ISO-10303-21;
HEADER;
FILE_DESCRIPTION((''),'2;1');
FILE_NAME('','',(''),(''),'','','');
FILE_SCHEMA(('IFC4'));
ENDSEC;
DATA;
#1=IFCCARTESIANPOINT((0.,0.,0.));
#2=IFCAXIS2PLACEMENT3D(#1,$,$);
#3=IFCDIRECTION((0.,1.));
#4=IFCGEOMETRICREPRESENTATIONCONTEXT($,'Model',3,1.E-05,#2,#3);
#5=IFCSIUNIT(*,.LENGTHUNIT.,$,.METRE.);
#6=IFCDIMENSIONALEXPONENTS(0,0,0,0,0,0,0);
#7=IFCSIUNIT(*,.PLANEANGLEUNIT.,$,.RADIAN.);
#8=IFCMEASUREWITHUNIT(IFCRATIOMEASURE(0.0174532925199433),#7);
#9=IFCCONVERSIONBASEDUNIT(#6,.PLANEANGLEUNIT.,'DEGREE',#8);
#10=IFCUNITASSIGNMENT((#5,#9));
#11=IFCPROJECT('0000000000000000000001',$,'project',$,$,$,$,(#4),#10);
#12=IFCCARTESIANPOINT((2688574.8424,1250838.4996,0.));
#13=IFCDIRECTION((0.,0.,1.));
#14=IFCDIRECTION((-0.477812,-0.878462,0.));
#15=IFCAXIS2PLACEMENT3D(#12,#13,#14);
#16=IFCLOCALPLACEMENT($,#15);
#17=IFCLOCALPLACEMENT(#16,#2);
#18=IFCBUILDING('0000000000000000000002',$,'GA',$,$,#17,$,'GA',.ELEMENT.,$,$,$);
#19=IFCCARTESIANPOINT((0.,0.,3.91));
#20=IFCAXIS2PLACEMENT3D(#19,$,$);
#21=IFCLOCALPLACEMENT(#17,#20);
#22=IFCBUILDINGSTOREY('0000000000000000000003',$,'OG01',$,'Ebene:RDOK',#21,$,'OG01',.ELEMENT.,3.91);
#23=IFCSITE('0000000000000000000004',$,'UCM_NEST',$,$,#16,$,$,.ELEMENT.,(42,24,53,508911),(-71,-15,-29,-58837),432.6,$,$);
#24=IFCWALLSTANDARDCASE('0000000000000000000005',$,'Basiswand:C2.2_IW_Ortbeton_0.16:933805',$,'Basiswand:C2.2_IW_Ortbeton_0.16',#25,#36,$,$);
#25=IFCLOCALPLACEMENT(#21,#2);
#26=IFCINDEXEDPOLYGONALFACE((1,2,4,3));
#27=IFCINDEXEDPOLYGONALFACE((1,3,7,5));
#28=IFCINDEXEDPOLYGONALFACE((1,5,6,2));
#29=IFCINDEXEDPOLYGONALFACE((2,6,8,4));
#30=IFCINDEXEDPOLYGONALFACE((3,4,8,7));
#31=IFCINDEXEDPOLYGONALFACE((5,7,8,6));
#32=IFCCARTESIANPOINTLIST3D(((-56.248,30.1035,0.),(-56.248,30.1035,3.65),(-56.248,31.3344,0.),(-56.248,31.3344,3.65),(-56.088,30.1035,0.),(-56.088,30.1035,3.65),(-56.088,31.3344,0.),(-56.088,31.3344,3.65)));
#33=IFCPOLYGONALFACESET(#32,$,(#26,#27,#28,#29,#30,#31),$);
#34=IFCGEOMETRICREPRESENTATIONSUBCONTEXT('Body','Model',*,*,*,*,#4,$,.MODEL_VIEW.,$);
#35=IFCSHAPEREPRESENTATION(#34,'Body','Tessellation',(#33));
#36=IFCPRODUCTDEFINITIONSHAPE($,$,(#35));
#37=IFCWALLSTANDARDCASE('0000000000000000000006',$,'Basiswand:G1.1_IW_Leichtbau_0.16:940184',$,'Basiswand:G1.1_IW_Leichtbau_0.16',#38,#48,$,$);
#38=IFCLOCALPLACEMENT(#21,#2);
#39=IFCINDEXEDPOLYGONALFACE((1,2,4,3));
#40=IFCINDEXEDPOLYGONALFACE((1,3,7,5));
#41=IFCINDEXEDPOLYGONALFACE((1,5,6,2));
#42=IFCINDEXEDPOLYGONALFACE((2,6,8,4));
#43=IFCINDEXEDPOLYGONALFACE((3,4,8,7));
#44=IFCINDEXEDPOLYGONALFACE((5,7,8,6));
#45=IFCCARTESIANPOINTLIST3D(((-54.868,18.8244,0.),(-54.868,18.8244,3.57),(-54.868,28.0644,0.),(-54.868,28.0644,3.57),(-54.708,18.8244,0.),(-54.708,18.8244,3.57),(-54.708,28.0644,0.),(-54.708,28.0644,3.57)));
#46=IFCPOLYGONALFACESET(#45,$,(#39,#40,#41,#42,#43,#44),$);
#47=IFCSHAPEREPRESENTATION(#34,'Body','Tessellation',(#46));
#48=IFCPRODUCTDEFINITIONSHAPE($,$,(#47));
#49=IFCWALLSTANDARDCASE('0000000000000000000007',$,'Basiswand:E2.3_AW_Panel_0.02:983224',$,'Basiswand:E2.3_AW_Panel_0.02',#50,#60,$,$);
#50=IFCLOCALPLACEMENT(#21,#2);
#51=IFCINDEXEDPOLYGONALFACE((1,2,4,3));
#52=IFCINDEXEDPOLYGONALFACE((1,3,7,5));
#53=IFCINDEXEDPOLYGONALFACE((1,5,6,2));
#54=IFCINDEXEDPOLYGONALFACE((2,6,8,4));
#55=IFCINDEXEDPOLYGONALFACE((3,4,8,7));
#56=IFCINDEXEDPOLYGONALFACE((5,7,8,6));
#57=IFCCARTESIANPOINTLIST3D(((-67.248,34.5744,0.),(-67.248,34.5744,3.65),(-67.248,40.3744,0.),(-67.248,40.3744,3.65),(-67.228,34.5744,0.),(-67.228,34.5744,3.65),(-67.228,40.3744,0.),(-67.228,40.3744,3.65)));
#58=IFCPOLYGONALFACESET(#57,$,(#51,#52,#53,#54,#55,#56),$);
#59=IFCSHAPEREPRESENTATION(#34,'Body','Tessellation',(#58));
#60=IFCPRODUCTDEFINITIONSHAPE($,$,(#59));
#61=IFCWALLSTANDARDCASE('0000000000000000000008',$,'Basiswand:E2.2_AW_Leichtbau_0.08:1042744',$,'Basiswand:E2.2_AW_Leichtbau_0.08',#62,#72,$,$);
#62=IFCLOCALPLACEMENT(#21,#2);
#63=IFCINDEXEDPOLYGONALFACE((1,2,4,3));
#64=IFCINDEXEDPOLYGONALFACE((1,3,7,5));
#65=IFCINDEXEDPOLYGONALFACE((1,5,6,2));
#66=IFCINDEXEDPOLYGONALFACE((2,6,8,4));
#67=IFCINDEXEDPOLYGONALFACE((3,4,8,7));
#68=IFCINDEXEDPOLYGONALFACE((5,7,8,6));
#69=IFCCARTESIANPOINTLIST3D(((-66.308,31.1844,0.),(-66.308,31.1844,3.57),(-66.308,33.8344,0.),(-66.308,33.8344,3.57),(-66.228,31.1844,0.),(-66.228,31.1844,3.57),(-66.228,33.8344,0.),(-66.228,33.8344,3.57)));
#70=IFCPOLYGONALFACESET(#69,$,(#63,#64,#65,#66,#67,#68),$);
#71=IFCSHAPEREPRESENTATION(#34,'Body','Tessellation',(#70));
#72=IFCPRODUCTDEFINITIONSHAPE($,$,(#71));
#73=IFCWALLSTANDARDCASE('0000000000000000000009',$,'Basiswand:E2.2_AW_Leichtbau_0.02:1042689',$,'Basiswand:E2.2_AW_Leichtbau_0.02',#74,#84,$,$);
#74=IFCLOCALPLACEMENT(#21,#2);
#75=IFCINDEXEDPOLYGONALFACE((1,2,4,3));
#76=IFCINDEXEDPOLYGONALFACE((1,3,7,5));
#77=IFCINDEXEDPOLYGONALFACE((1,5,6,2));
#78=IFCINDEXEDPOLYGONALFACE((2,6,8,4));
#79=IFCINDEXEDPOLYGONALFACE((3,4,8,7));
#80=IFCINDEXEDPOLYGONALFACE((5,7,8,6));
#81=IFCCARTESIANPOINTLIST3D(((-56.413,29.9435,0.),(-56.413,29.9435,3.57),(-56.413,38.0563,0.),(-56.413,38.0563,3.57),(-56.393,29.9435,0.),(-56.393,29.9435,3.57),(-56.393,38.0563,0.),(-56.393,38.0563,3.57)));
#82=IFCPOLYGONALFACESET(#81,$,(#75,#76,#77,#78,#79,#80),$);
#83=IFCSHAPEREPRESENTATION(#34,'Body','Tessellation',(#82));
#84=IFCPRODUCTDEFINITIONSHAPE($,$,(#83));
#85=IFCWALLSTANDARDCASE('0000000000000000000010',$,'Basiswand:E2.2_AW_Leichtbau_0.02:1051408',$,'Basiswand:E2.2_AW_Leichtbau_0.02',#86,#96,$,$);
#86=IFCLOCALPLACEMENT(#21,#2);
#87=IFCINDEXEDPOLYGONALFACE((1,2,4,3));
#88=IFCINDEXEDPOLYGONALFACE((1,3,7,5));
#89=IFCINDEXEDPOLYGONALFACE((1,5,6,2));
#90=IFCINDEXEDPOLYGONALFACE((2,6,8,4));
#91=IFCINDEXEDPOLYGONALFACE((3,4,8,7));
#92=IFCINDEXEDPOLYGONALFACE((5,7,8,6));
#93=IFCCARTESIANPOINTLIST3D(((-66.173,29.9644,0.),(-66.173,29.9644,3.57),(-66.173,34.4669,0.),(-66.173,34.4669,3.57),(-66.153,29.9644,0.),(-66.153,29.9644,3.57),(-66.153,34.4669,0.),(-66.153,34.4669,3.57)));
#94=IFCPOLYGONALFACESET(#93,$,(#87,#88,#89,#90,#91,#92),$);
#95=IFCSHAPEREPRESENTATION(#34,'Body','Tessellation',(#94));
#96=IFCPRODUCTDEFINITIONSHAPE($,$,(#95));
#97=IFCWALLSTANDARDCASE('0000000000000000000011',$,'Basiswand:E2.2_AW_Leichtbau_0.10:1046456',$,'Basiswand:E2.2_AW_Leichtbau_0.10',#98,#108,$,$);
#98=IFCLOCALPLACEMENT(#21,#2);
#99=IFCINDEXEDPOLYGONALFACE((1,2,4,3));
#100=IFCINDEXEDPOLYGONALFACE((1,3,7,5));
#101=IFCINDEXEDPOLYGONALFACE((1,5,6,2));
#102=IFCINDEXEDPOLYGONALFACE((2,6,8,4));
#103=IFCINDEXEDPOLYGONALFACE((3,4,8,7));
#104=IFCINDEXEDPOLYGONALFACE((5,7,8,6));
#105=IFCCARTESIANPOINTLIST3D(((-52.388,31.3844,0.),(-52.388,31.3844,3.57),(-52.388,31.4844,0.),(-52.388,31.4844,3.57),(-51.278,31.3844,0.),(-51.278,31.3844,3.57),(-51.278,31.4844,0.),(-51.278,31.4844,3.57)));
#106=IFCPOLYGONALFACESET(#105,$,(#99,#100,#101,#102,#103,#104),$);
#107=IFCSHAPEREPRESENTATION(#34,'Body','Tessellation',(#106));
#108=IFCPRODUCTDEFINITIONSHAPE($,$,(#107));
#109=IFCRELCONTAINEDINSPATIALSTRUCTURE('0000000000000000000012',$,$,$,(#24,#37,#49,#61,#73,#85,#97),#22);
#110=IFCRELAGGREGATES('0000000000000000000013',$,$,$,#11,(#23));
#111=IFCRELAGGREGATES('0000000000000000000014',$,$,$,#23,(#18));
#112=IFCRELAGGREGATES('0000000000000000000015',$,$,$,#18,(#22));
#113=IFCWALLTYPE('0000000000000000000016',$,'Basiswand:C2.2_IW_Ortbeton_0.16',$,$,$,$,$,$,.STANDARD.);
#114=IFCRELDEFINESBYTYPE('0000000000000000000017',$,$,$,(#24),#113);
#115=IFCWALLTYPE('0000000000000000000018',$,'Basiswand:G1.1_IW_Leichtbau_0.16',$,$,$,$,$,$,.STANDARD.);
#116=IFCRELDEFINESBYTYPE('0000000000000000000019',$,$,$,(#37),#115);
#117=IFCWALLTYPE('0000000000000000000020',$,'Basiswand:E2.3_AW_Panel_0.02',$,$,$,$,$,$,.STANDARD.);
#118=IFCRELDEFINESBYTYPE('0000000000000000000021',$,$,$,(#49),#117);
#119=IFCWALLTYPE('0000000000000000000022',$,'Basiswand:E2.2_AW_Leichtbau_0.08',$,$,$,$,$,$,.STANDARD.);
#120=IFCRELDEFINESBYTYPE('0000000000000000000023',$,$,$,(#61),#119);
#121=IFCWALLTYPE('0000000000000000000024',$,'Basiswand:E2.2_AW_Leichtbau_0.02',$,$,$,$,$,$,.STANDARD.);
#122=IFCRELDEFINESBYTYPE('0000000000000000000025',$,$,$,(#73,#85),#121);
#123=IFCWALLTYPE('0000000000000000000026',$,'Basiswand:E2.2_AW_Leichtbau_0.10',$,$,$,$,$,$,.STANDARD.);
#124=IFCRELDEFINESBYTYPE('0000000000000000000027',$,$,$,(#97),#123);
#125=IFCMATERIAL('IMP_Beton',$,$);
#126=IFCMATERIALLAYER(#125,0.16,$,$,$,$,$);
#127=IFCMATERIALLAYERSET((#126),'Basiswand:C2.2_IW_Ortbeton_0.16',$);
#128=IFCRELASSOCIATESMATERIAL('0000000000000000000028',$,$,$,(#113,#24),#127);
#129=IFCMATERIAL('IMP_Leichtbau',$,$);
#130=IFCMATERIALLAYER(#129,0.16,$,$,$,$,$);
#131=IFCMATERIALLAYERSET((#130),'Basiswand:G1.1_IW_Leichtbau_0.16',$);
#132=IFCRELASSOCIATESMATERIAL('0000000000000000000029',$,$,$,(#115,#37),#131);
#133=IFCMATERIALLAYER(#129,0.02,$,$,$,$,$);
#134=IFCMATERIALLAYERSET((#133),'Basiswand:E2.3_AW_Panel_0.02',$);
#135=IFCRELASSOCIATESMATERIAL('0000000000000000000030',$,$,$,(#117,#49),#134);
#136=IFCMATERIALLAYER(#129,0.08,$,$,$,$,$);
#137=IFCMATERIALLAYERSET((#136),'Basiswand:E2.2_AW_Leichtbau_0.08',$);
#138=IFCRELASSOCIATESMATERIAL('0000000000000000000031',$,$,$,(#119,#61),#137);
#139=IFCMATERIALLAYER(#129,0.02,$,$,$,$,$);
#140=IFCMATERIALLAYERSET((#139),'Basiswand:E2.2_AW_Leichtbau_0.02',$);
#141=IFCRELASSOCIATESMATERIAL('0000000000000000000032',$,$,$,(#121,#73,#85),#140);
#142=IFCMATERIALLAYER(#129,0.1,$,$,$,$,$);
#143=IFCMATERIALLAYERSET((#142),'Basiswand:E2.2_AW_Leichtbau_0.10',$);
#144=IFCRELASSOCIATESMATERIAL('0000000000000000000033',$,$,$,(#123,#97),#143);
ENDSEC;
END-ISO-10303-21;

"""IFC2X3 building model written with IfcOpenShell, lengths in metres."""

from ifc_helpers import new_model, entity, si_unit, converted_unit, direction, frame, frame_2d, origin, place, context, subcontext, project, spatial, polyline, rectangle, extrude, clip, bounded_halfspace, material, layer, layer_set, layer_usage, type_object, element, save


model = new_model("IFC2X3")

# Units and contexts
model_context = context("Model", 3, precision=1e-05, world=origin(), true_north=direction((0.0, 1.0)))
body_context = subcontext(model_context, "Body", "Model", "MODEL_VIEW")
ifc_project = project(units=[si_unit("LENGTHUNIT", "METRE"), converted_unit("PLANEANGLEUNIT", "DEGREE", entity("IfcRatioMeasure", 0.0174532925199433), si_unit("PLANEANGLEUNIT", "RADIAN"), dimensions=[0, 0, 0, 0, 0, 0, 0])], contexts=[model_context])

# Site, building, storey
site_placement = place(None, frame((2688574.8424, 1250838.4996, 0.0), z_axis=(0.0, 0.0, 1.0), x_axis=(-0.477812, -0.878462, 0.0)))
site = spatial("IfcSite", under=ifc_project, at=site_placement, Name="UCM_NEST", CompositionType="ELEMENT", RefLatitude=(42, 24, 53, 508911), RefLongitude=(-71, -15, -29, -58837), RefElevation=432.6)
building_placement = place(site_placement, origin())
building = spatial("IfcBuilding", under=site, at=building_placement, Name="GA", LongName="GA", CompositionType="ELEMENT")
storey_placement = place(building_placement, frame((0.0, 0.0, 3.91)))
storey = spatial("IfcBuildingStorey", under=building, at=storey_placement, Name="OG01", ObjectType="Ebene:RDOK", LongName="OG01", CompositionType="ELEMENT", Elevation=3.91)

# Shared definitions
ifc_material_1 = material(Name="IMP_Beton")

# Shared definitions
ifc_material_2 = material(Name="IMP_Leichtbau")

# Wall
ifc_layer_1 = layer(ifc_material_1, 0.16)
ifc_layer_set_1 = layer_set([ifc_layer_1], Name="Basiswand:C2.2_IW_Ortbeton_0.16")
ifc_layer_usage_1 = layer_usage(ifc_layer_set_1, "AXIS2", "NEGATIVE", 0.08)
wall_type_1 = type_object("IfcWallType", Name="Basiswand:C2.2_IW_Ortbeton_0.16", PredefinedType="STANDARD", material=ifc_layer_set_1)
wall_1_placement = place(storey_placement, frame((-56.168, 31.3344, 0.0), z_axis=(0.0, 0.0, 1.0), x_axis=(0.0, -1.0, 0.0)))
element("IfcWallStandardCase", 1, at=wall_1_placement, inside=storey, type_object=wall_type_1, material=ifc_layer_usage_1, Name="Basiswand:C2.2_IW_Ortbeton_0.16:933805", ObjectType="Basiswand:C2.2_IW_Ortbeton_0.16", context=body_context, shape_type="SweptSolid", body=[
    extrude(rectangle(XDim=1.2309, YDim=0.16, at=frame_2d((0.6155, 0.0), x_axis=(-1.0, 0.0))), origin(), (0.0, 0.0, 1.0), 3.65),
])

# Shared definitions
ifc_layer_2 = layer(ifc_material_2, 0.16)
ifc_layer_set_2 = layer_set([ifc_layer_2], Name="Basiswand:G1.1_IW_Leichtbau_0.16")
wall_type_2 = type_object("IfcWallType", Name="Basiswand:G1.1_IW_Leichtbau_0.16", PredefinedType="STANDARD", material=ifc_layer_set_2)

# Walls
ifc_layer_usage_2 = layer_usage(ifc_layer_set_2, "AXIS2", "NEGATIVE", 0.08)
wall_2_placement = place(storey_placement, frame((-54.788, 28.0644, 0.0), z_axis=(0.0, 0.0, 1.0), x_axis=(0.0, -1.0, 0.0)))
element("IfcWallStandardCase", 2, at=wall_2_placement, inside=storey, type_object=wall_type_2, material=ifc_layer_usage_2, Name="Basiswand:G1.1_IW_Leichtbau_0.16:940184", ObjectType="Basiswand:G1.1_IW_Leichtbau_0.16", context=body_context, shape_type="Clipping", body=[
    clip(extrude(rectangle(XDim=9.24, YDim=0.16, at=frame_2d((4.62, 0.0), x_axis=(-1.0, 0.0))), origin(), (0.0, 0.0, 1.0), 3.57), bounded_halfspace(frame((0.0, -0.08, 3.57), z_axis=(0.0, 0.0, -1.0), x_axis=(1.0, 0.0, 0.0)), True, frame((0.0, -0.08, 3.57), z_axis=(0.0, 0.0, -1.0), x_axis=(1.0, 0.0, 0.0)), polyline([(0.0, 0.0), (0.0, -0.16), (9.24, -0.16), (9.24, 0.0), (0.0, 0.0)]))),
])
ifc_layer_3 = layer(ifc_material_2, 0.02)
ifc_layer_set_3 = layer_set([ifc_layer_3], Name="Basiswand:E2.3_AW_Panel_0.02")
ifc_layer_usage_3 = layer_usage(ifc_layer_set_3, "AXIS2", "NEGATIVE", 0.01)
wall_type_3 = type_object("IfcWallType", Name="Basiswand:E2.3_AW_Panel_0.02", PredefinedType="STANDARD", material=ifc_layer_set_3)
wall_3_placement = place(storey_placement, frame((-67.238, 34.5744, 0.0), z_axis=(0.0, 0.0, 1.0), x_axis=(0.0, 1.0, 0.0)))
element("IfcWallStandardCase", 3, at=wall_3_placement, inside=storey, type_object=wall_type_3, material=ifc_layer_usage_3, Name="Basiswand:E2.3_AW_Panel_0.02:983224", ObjectType="Basiswand:E2.3_AW_Panel_0.02", context=body_context, shape_type="SweptSolid", body=[
    extrude(rectangle(XDim=5.8, YDim=0.02, at=frame_2d((2.9, 0.0), x_axis=(-1.0, 0.0))), origin(), (0.0, 0.0, 1.0), 3.65),
])

# Shared definitions
ifc_layer_4 = layer(ifc_material_2, 0.08)
ifc_layer_set_4 = layer_set([ifc_layer_4], Name="Basiswand:E2.2_AW_Leichtbau_0.08")
wall_type_4 = type_object("IfcWallType", Name="Basiswand:E2.2_AW_Leichtbau_0.08", PredefinedType="STANDARD", material=ifc_layer_set_4)

# Walls
ifc_layer_usage_4 = layer_usage(ifc_layer_set_4, "AXIS2", "NEGATIVE", 0.04)
wall_4_placement = place(storey_placement, frame((-66.268, 33.8344, 0.0), z_axis=(0.0, 0.0, 1.0), x_axis=(0.0, -1.0, 0.0)))
element("IfcWallStandardCase", 4, at=wall_4_placement, inside=storey, type_object=wall_type_4, material=ifc_layer_usage_4, Name="Basiswand:E2.2_AW_Leichtbau_0.08:1042744", ObjectType="Basiswand:E2.2_AW_Leichtbau_0.08", context=body_context, shape_type="Clipping", body=[
    clip(extrude(rectangle(XDim=2.65, YDim=0.08, at=frame_2d((1.325, 0.0), x_axis=(-1.0, 0.0))), origin(), (0.0, 0.0, 1.0), 3.57), bounded_halfspace(frame((0.0, -0.04, 3.57), z_axis=(0.0, 0.0, -1.0), x_axis=(1.0, 0.0, 0.0)), True, frame((0.0, -0.04, 3.57), z_axis=(0.0, 0.0, -1.0), x_axis=(1.0, 0.0, 0.0)), polyline([(0.0, 0.0), (0.0, -0.08), (2.65, -0.08), (2.65, 0.0), (0.0, 0.0)]))),
])
ifc_layer_5 = layer(ifc_material_2, 0.02)
ifc_layer_set_5 = layer_set([ifc_layer_5], Name="Basiswand:E2.2_AW_Leichtbau_0.02")
ifc_layer_usage_5 = layer_usage(ifc_layer_set_5, "AXIS2", "NEGATIVE", 0.01)
wall_type_5 = type_object("IfcWallType", Name="Basiswand:E2.2_AW_Leichtbau_0.02", PredefinedType="STANDARD", material=ifc_layer_set_5)
wall_5_placement = place(storey_placement, frame((-56.403, 29.9435, 0.0), z_axis=(0.0, 0.0, 1.0), x_axis=(0.0, 1.0, 0.0)))
element("IfcWallStandardCase", 5, at=wall_5_placement, inside=storey, type_object=wall_type_5, material=ifc_layer_usage_5, Name="Basiswand:E2.2_AW_Leichtbau_0.02:1042689", ObjectType="Basiswand:E2.2_AW_Leichtbau_0.02", context=body_context, shape_type="Clipping", body=[
    clip(extrude(rectangle(XDim=8.1128, YDim=0.02, at=frame_2d((4.0564, 0.0), x_axis=(-1.0, 0.0))), origin(), (0.0, 0.0, 1.0), 3.57), bounded_halfspace(frame((0.0, -0.01, 3.57), z_axis=(0.0, 0.0, -1.0), x_axis=(-1.0, 0.0, 0.0)), True, frame((0.0, -0.01, 3.57), z_axis=(0.0, 0.0, -1.0), x_axis=(-1.0, 0.0, 0.0)), polyline([(0.0, 0.0), (0.0, 0.02), (-8.1128, 0.02), (-8.1128, 0.0), (0.0, 0.0)]))),
])
ifc_layer_usage_6 = layer_usage(ifc_layer_set_5, "AXIS2", "NEGATIVE", 0.01)
wall_6_placement = place(storey_placement, frame((-66.163, 29.9644, 0.0), z_axis=(0.0, 0.0, 1.0), x_axis=(0.0, 1.0, 0.0)))
element("IfcWallStandardCase", 6, at=wall_6_placement, inside=storey, type_object=wall_type_5, material=ifc_layer_usage_6, Name="Basiswand:E2.2_AW_Leichtbau_0.02:1051408", ObjectType="Basiswand:E2.2_AW_Leichtbau_0.02", context=body_context, shape_type="Clipping", body=[
    clip(extrude(rectangle(XDim=4.5024, YDim=0.02, at=frame_2d((2.2512, 0.0), x_axis=(-1.0, 0.0))), origin(), (0.0, 0.0, 1.0), 3.57), bounded_halfspace(frame((0.0, -0.01, 3.57), z_axis=(0.0, 0.0, -1.0), x_axis=(-1.0, 0.0, 0.0)), True, frame((0.0, -0.01, 3.57), z_axis=(0.0, 0.0, -1.0), x_axis=(-1.0, 0.0, 0.0)), polyline([(0.0, 0.0), (0.0, 0.02), (-4.5024, 0.02), (-4.5024, 0.0), (0.0, 0.0)]))),
])
ifc_layer_6 = layer(ifc_material_2, 0.1)
ifc_layer_set_6 = layer_set([ifc_layer_6], Name="Basiswand:E2.2_AW_Leichtbau_0.10")
ifc_layer_usage_7 = layer_usage(ifc_layer_set_6, "AXIS2", "NEGATIVE", 0.05)
wall_type_6 = type_object("IfcWallType", Name="Basiswand:E2.2_AW_Leichtbau_0.10", PredefinedType="STANDARD", material=ifc_layer_set_6)
wall_7_placement = place(storey_placement, frame((-51.278, 31.4344, 0.0), z_axis=(0.0, 0.0, 1.0), x_axis=(-1.0, 0.0, 0.0)))
element("IfcWallStandardCase", 7, at=wall_7_placement, inside=storey, type_object=wall_type_6, material=ifc_layer_usage_7, Name="Basiswand:E2.2_AW_Leichtbau_0.10:1046456", ObjectType="Basiswand:E2.2_AW_Leichtbau_0.10", context=body_context, shape_type="Clipping", body=[
    clip(extrude(rectangle(XDim=1.11, YDim=0.1, at=frame_2d((0.555, 0.0), x_axis=(-1.0, 0.0))), origin(), (0.0, 0.0, 1.0), 3.57), bounded_halfspace(frame((0.0, -0.05, 3.57), z_axis=(0.0, 0.0, -1.0), x_axis=(0.0, 1.0, 0.0)), True, frame((0.0, -0.05, 3.57), z_axis=(0.0, 0.0, -1.0), x_axis=(0.0, 1.0, 0.0)), polyline([(0.0, 0.0), (0.1, 0.0), (0.1, 1.11), (0.0, 1.11), (0.0, 0.0)]))),
])

save(model, "model.ifc")
